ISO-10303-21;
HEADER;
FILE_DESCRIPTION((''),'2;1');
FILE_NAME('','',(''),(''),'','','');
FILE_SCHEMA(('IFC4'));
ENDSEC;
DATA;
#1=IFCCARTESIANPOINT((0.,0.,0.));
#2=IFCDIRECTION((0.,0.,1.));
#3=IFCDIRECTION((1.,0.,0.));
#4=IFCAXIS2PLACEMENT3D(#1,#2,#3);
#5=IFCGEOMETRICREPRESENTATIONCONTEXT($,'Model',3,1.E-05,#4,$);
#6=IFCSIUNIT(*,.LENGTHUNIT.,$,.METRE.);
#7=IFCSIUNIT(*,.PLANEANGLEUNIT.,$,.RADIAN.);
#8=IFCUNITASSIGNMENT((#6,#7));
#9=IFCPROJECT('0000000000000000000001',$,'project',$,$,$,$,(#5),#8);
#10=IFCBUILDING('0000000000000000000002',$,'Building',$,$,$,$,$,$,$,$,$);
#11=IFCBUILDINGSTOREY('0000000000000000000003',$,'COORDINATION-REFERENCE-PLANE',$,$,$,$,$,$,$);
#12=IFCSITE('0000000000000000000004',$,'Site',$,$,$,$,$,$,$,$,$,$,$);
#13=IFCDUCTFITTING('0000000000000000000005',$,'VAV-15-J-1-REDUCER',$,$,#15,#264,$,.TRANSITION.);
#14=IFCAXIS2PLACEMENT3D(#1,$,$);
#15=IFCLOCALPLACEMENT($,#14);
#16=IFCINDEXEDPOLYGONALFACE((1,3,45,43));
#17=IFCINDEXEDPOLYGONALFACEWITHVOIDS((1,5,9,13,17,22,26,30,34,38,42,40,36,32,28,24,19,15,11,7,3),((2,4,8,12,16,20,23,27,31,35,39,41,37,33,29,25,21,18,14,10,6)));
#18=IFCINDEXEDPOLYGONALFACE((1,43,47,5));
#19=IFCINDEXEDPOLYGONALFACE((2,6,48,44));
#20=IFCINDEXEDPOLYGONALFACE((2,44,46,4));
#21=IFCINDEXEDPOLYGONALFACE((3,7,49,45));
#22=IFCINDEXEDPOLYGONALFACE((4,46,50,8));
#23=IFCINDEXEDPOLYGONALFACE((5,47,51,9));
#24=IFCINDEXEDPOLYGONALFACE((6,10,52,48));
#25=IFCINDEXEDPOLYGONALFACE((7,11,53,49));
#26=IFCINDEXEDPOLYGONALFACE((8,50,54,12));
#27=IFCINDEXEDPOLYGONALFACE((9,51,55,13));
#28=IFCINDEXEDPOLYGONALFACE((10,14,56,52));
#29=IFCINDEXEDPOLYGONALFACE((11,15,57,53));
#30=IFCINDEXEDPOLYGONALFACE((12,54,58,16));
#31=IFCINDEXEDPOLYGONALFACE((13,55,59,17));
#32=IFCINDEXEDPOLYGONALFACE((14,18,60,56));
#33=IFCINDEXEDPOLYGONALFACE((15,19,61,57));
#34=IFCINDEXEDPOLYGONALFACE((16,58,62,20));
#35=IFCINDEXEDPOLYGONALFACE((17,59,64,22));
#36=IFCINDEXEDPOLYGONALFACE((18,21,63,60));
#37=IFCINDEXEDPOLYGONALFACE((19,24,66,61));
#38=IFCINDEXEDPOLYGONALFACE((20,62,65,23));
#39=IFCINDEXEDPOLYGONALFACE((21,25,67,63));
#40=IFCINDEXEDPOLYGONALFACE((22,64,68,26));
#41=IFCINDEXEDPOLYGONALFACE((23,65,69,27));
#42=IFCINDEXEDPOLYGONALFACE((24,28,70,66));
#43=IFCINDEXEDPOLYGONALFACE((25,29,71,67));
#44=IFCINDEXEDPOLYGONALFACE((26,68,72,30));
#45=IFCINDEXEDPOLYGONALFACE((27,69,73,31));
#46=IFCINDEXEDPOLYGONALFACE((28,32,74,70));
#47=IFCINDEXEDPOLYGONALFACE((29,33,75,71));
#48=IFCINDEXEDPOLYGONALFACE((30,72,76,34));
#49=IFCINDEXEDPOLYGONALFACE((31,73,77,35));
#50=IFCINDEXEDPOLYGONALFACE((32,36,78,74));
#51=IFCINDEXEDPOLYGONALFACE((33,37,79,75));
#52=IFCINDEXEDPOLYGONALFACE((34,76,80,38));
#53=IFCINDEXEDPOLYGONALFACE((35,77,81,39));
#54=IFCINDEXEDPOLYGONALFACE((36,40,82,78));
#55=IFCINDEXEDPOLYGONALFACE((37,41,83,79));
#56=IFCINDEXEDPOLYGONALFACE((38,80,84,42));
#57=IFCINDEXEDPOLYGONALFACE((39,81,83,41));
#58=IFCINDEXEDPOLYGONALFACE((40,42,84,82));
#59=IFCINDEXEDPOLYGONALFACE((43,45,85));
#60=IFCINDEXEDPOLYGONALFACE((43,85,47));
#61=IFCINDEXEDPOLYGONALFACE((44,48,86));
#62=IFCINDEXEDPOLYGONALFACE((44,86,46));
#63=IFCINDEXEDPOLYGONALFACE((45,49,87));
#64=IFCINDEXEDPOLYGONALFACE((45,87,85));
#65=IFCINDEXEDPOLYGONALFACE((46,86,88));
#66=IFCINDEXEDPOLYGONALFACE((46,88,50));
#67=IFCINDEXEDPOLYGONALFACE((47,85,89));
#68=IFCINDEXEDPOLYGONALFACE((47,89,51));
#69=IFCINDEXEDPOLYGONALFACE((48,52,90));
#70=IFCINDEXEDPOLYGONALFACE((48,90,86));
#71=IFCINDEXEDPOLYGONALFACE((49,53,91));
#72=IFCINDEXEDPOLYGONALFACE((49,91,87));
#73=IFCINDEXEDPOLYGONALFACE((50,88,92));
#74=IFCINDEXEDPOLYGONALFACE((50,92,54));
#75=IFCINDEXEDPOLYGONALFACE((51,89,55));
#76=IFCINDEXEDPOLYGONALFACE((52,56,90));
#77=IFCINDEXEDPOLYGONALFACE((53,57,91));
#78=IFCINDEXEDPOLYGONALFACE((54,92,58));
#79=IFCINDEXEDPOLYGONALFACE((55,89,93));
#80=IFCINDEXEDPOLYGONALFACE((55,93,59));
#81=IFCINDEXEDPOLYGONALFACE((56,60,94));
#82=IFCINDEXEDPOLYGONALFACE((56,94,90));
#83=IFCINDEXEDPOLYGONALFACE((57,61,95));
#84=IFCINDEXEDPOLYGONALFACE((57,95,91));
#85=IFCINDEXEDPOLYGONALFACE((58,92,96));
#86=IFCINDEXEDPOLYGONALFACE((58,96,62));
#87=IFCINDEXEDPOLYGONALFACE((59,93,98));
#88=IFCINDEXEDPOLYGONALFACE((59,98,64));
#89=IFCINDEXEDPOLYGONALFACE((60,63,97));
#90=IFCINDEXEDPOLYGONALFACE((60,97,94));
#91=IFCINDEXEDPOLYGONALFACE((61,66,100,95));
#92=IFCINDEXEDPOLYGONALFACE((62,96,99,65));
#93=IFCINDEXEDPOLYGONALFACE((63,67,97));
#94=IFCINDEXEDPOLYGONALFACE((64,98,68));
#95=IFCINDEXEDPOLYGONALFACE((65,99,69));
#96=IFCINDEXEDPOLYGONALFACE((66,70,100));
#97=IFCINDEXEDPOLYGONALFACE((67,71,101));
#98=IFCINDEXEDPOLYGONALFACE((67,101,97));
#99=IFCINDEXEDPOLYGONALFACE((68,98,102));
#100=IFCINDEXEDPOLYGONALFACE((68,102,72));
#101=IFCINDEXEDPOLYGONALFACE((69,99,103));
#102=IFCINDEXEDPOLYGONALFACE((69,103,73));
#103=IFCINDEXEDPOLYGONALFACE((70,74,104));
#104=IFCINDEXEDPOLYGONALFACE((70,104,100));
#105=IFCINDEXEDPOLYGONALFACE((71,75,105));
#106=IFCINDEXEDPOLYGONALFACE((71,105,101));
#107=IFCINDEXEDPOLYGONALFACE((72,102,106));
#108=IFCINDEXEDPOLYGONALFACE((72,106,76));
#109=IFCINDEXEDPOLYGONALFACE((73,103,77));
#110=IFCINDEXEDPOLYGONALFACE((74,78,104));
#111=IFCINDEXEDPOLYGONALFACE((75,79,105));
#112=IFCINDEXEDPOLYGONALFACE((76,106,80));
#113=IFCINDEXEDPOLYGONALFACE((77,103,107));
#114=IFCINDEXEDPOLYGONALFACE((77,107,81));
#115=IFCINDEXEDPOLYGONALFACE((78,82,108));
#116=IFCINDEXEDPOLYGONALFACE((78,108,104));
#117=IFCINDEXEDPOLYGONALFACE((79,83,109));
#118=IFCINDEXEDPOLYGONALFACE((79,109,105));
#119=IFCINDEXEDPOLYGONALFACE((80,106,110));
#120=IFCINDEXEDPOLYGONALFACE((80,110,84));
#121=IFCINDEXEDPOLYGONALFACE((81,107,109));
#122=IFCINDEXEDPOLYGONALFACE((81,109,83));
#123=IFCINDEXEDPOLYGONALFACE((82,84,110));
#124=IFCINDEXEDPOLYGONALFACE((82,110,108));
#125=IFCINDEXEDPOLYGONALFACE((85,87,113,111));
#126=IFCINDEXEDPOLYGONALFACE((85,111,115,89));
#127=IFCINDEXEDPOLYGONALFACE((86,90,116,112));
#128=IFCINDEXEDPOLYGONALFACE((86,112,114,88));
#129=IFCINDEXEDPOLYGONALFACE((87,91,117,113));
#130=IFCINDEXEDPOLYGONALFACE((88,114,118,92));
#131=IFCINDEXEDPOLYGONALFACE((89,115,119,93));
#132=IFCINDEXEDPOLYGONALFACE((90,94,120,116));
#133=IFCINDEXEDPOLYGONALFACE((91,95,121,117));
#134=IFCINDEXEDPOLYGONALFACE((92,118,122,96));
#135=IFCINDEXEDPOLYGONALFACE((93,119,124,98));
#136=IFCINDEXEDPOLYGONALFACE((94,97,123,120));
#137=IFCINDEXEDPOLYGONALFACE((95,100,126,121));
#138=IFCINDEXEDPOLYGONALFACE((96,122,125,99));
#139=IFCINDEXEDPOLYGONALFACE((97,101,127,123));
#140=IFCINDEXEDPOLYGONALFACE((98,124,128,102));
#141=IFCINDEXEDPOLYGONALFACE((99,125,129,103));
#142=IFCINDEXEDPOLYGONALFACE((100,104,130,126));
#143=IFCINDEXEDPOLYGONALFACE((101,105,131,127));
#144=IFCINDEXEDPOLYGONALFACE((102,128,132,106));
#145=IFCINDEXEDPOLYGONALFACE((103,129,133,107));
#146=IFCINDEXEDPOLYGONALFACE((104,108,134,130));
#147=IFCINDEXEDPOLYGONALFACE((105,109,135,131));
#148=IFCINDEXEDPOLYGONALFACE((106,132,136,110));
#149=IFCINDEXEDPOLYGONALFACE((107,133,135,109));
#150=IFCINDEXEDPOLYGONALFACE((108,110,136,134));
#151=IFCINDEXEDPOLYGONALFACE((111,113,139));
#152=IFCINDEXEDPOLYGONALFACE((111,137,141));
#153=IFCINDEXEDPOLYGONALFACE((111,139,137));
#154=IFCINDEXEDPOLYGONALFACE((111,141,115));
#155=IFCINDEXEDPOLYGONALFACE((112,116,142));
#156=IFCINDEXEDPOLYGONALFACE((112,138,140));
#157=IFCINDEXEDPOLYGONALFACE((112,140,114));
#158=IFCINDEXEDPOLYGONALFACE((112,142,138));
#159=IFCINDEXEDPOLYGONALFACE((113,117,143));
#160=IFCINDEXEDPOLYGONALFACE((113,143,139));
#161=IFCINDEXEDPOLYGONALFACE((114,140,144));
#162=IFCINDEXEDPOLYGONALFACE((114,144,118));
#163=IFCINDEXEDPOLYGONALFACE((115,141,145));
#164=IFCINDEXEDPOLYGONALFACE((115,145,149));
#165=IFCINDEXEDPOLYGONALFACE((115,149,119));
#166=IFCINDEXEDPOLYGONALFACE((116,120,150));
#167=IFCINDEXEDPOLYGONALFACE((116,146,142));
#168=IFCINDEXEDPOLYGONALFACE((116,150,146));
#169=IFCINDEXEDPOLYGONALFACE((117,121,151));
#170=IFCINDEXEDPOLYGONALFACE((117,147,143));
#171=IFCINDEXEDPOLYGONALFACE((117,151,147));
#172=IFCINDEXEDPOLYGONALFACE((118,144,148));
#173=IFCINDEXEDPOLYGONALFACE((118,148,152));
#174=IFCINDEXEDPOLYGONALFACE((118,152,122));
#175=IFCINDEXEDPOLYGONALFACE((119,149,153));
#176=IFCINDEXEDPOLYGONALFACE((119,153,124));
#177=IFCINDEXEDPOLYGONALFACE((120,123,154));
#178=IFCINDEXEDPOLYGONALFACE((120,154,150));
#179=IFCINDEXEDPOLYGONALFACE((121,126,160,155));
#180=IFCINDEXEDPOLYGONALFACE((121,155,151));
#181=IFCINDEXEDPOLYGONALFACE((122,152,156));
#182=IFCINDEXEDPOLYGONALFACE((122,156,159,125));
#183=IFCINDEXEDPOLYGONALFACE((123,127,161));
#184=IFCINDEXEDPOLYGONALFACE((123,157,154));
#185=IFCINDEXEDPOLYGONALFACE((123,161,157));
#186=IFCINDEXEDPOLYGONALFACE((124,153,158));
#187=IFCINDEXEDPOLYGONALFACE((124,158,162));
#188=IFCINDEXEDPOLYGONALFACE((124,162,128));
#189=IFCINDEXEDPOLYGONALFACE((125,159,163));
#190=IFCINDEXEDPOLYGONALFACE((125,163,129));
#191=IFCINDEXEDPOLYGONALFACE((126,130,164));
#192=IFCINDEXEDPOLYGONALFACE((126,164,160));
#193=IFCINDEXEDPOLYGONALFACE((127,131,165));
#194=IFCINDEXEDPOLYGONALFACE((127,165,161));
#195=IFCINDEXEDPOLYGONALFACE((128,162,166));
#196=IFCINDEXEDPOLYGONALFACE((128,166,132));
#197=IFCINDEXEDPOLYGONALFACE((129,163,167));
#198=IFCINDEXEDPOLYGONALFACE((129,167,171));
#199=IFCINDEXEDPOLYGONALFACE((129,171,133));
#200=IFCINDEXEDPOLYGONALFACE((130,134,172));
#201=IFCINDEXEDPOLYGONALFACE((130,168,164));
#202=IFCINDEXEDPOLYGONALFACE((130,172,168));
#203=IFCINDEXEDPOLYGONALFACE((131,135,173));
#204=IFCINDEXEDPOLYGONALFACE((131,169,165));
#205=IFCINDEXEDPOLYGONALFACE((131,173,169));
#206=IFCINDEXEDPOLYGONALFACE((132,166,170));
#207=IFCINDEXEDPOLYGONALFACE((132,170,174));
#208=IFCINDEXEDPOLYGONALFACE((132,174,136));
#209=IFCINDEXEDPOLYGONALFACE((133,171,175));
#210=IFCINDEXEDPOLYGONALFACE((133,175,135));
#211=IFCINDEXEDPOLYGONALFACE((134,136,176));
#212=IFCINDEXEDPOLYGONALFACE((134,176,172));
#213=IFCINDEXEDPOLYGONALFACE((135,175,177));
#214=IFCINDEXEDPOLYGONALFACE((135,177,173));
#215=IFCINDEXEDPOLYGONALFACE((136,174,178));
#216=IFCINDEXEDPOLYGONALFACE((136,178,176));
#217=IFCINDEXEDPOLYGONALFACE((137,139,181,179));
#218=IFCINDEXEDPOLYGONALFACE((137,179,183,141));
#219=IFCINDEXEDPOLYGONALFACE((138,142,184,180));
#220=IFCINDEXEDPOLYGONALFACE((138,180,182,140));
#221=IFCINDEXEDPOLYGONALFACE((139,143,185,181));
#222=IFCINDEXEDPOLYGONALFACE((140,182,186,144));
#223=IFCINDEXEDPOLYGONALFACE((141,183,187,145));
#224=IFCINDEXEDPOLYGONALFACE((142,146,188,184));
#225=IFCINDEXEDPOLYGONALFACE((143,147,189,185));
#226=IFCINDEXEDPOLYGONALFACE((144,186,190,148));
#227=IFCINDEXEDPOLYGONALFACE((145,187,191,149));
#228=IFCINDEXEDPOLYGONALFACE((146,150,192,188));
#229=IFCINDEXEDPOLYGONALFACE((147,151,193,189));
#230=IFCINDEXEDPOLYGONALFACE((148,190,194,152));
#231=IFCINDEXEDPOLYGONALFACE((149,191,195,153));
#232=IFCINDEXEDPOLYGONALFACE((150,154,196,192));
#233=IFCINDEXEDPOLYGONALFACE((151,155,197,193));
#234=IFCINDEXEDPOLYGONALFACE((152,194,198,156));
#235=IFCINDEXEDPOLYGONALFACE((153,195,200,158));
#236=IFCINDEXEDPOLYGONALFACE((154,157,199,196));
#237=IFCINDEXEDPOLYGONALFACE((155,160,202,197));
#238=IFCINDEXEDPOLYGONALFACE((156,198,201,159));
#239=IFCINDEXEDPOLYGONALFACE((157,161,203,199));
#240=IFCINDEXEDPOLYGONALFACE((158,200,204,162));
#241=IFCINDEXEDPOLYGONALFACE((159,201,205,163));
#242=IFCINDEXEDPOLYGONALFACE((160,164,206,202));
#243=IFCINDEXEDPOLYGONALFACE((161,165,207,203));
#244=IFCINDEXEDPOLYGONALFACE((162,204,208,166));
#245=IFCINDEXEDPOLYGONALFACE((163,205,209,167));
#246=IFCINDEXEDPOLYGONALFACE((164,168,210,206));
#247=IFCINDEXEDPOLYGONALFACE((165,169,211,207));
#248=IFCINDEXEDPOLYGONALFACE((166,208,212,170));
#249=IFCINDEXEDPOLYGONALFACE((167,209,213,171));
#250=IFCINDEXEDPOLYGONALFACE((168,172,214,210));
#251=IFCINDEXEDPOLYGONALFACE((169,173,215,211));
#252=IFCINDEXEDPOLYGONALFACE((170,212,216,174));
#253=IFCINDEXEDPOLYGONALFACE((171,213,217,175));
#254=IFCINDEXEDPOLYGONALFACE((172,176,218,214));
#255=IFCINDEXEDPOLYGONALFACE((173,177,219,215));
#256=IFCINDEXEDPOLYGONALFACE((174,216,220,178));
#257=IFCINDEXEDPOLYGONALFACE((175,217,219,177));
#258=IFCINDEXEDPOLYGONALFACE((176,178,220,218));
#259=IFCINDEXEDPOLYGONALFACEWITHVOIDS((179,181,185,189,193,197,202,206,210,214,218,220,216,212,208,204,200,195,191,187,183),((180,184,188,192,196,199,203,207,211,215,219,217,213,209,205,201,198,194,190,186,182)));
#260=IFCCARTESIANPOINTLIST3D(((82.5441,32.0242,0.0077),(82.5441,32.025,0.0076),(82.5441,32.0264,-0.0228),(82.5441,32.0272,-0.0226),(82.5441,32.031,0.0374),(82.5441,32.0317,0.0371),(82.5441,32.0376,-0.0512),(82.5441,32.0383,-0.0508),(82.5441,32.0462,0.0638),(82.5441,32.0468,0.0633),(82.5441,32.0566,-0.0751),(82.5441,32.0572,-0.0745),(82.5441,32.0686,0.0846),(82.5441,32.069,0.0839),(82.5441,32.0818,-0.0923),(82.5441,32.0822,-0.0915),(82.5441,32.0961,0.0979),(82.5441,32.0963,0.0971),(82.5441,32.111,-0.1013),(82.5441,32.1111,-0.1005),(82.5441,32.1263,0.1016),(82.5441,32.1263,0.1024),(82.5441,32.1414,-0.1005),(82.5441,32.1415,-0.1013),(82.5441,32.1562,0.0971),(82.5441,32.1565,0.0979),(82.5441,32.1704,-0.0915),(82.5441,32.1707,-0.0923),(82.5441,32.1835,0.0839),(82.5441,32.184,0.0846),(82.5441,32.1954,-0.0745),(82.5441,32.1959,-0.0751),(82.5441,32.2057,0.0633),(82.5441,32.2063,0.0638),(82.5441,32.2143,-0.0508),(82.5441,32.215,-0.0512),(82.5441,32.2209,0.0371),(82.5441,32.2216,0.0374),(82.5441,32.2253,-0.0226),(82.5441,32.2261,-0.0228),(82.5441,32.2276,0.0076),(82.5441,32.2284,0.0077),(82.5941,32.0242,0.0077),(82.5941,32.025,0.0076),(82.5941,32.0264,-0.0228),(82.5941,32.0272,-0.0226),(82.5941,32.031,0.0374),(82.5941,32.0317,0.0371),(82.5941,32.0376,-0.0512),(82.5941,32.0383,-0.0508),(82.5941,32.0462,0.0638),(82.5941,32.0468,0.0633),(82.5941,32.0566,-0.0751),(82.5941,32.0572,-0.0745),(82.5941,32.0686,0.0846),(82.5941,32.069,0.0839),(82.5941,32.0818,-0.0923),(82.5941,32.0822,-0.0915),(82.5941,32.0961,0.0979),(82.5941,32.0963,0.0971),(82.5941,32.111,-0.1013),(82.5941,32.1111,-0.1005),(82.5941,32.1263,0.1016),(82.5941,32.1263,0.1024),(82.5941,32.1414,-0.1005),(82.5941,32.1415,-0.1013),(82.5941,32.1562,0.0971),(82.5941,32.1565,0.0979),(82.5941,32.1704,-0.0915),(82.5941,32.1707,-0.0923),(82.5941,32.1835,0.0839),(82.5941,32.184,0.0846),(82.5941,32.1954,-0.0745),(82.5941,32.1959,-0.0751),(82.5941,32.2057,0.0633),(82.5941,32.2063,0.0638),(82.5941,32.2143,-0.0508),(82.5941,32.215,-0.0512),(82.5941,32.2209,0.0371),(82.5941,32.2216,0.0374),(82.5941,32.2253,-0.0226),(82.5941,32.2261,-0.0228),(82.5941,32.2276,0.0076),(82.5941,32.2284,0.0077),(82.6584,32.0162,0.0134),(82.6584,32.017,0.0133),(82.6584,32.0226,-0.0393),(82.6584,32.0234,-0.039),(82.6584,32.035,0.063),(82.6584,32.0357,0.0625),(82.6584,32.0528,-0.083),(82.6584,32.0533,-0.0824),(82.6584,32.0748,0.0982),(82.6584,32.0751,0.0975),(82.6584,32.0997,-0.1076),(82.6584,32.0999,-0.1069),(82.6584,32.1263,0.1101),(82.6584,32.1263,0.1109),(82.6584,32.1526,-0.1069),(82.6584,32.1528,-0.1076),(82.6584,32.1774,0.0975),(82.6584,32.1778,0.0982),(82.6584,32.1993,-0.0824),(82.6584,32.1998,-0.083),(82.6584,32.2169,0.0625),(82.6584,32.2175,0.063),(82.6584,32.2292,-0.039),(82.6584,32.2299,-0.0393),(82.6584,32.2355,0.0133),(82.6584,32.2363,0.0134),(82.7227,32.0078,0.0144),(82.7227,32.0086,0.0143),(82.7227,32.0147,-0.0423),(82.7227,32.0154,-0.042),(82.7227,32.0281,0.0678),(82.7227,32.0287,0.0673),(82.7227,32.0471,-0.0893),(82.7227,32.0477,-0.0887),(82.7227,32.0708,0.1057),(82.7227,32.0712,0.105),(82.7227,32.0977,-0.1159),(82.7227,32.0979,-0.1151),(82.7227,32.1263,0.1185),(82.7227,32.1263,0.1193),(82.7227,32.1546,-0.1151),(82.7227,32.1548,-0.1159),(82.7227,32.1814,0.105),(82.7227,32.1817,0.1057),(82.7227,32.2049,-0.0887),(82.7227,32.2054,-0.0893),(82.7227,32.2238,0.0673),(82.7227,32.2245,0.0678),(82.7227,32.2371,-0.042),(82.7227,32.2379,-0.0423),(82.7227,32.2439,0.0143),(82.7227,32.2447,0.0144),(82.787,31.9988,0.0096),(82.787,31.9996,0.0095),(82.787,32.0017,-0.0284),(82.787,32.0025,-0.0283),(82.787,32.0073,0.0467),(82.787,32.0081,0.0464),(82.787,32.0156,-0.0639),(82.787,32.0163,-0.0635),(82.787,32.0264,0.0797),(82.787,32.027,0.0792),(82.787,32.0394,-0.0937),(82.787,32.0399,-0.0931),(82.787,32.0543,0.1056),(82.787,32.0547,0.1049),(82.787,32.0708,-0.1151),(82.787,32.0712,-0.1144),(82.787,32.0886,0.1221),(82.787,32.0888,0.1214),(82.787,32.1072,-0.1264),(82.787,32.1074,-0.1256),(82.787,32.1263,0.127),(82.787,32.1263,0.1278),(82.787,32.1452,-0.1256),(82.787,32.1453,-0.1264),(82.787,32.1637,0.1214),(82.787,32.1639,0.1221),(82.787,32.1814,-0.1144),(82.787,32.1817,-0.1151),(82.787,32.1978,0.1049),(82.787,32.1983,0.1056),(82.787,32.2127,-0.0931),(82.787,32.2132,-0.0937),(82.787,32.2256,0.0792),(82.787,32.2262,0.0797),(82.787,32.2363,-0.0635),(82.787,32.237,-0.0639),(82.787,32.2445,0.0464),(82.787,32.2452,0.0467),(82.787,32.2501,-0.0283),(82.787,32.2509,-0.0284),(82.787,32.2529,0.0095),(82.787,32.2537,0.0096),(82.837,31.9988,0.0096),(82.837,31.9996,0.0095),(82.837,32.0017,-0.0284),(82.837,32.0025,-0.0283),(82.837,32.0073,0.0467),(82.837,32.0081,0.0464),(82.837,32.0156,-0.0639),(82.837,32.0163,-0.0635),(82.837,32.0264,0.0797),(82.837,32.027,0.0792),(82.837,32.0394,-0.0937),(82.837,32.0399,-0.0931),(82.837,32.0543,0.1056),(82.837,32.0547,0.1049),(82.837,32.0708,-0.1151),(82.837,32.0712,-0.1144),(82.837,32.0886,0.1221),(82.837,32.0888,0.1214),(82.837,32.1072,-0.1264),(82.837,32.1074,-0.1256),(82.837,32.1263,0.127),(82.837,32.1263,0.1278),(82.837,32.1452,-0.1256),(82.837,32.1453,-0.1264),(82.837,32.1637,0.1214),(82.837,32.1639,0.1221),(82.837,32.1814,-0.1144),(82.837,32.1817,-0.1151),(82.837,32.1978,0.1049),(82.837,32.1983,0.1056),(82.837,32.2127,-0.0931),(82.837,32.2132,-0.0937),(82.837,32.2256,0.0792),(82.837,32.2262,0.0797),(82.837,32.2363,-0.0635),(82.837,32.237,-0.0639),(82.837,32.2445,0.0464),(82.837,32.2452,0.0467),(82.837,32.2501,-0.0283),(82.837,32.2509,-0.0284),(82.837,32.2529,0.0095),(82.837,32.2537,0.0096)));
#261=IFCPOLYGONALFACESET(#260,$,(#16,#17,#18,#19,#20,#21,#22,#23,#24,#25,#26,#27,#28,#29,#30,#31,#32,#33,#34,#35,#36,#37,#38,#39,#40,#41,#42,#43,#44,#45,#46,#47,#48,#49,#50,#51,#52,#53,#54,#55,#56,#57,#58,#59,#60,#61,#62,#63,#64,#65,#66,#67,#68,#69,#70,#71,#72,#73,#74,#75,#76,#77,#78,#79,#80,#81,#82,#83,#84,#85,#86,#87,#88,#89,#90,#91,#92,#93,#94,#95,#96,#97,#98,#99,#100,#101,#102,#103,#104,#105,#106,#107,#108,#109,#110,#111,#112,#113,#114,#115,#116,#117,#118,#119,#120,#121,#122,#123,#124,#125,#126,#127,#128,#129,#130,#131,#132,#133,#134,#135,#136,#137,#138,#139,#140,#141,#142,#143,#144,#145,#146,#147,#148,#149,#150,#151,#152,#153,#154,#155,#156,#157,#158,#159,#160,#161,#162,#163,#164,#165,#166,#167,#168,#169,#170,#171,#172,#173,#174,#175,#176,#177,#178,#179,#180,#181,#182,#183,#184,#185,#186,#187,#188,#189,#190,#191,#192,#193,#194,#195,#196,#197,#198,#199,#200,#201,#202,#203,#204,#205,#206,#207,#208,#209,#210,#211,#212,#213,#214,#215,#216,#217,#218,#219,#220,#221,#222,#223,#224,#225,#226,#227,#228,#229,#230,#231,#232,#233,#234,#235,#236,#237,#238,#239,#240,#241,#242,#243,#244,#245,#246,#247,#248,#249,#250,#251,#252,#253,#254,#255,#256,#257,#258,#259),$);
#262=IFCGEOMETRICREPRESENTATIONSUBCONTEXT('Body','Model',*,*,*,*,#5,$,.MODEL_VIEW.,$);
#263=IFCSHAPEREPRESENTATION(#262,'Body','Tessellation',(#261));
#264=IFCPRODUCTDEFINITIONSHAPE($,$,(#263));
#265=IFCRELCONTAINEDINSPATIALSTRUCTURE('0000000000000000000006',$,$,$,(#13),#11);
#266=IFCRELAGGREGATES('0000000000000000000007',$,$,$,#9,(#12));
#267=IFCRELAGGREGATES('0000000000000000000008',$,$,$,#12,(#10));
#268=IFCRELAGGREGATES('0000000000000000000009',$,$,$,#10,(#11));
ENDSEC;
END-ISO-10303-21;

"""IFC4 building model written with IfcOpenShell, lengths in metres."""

from ifc_helpers import new_model, entity, si_unit, frame, origin_with_axes, place, context, subcontext, project, spatial, element, save


model = new_model("IFC4")

# Units and contexts
model_context = context("Model", 3, precision=1e-05, world=origin_with_axes())
body_context_1 = subcontext(model_context, "Body", "Model", "MODEL_VIEW")
ifc_project = project(units=[si_unit("LENGTHUNIT", "METRE"), si_unit("PLANEANGLEUNIT", "RADIAN")], contexts=[model_context])

# Site, building, storey
site = spatial("IfcSite", under=ifc_project, Name="Site")
building = spatial("IfcBuilding", under=site, Name="Building")
storey = spatial("IfcBuildingStorey", under=building, Name="COORDINATION-REFERENCE-PLANE")

# Duct fitting
for number, where, z_axis, x_axis, name in (
    (1, (82.837, 32.1263, 0.0), (0.0, -1.0, 0.0), (0.0, 0.0, 1.0), "VAV-15-J-1-REDUCER"),
):
    element("IfcDuctFitting", number, at=place(None, frame(where, z_axis=z_axis, x_axis=x_axis)), inside=storey, Name=name, PredefinedType="TRANSITION", context=body_context_1, shape_type="SweptSolid", body=[
        entity("IfcRevolvedAreaSolid", entity("IfcArbitraryClosedProfileDef", "AREA", None, entity("IfcPolyline", [entity("IfcCartesianPoint", [0.1278, 0.0]), entity("IfcCartesianPoint", [0.1278, 0.05]), entity("IfcCartesianPoint", [0.1024, 0.2429]), entity("IfcCartesianPoint", [0.1024, 0.2929]), entity("IfcCartesianPoint", [0.1016, 0.2929]), entity("IfcCartesianPoint", [0.1016, 0.2429]), entity("IfcCartesianPoint", [0.127, 0.05]), entity("IfcCartesianPoint", [0.127, 0.0]), entity("IfcCartesianPoint", [0.1278, 0.0])])), entity("IfcAxis2Placement3D", entity("IfcCartesianPoint", [0.0, 0.0, 0.0])), entity("IfcAxis1Placement", entity("IfcCartesianPoint", [0.0, 0.0, 0.0]), entity("IfcDirection", [0.0, 1.0, 0.0])), 6.283185),
    ])

save(model, "model.ifc")
